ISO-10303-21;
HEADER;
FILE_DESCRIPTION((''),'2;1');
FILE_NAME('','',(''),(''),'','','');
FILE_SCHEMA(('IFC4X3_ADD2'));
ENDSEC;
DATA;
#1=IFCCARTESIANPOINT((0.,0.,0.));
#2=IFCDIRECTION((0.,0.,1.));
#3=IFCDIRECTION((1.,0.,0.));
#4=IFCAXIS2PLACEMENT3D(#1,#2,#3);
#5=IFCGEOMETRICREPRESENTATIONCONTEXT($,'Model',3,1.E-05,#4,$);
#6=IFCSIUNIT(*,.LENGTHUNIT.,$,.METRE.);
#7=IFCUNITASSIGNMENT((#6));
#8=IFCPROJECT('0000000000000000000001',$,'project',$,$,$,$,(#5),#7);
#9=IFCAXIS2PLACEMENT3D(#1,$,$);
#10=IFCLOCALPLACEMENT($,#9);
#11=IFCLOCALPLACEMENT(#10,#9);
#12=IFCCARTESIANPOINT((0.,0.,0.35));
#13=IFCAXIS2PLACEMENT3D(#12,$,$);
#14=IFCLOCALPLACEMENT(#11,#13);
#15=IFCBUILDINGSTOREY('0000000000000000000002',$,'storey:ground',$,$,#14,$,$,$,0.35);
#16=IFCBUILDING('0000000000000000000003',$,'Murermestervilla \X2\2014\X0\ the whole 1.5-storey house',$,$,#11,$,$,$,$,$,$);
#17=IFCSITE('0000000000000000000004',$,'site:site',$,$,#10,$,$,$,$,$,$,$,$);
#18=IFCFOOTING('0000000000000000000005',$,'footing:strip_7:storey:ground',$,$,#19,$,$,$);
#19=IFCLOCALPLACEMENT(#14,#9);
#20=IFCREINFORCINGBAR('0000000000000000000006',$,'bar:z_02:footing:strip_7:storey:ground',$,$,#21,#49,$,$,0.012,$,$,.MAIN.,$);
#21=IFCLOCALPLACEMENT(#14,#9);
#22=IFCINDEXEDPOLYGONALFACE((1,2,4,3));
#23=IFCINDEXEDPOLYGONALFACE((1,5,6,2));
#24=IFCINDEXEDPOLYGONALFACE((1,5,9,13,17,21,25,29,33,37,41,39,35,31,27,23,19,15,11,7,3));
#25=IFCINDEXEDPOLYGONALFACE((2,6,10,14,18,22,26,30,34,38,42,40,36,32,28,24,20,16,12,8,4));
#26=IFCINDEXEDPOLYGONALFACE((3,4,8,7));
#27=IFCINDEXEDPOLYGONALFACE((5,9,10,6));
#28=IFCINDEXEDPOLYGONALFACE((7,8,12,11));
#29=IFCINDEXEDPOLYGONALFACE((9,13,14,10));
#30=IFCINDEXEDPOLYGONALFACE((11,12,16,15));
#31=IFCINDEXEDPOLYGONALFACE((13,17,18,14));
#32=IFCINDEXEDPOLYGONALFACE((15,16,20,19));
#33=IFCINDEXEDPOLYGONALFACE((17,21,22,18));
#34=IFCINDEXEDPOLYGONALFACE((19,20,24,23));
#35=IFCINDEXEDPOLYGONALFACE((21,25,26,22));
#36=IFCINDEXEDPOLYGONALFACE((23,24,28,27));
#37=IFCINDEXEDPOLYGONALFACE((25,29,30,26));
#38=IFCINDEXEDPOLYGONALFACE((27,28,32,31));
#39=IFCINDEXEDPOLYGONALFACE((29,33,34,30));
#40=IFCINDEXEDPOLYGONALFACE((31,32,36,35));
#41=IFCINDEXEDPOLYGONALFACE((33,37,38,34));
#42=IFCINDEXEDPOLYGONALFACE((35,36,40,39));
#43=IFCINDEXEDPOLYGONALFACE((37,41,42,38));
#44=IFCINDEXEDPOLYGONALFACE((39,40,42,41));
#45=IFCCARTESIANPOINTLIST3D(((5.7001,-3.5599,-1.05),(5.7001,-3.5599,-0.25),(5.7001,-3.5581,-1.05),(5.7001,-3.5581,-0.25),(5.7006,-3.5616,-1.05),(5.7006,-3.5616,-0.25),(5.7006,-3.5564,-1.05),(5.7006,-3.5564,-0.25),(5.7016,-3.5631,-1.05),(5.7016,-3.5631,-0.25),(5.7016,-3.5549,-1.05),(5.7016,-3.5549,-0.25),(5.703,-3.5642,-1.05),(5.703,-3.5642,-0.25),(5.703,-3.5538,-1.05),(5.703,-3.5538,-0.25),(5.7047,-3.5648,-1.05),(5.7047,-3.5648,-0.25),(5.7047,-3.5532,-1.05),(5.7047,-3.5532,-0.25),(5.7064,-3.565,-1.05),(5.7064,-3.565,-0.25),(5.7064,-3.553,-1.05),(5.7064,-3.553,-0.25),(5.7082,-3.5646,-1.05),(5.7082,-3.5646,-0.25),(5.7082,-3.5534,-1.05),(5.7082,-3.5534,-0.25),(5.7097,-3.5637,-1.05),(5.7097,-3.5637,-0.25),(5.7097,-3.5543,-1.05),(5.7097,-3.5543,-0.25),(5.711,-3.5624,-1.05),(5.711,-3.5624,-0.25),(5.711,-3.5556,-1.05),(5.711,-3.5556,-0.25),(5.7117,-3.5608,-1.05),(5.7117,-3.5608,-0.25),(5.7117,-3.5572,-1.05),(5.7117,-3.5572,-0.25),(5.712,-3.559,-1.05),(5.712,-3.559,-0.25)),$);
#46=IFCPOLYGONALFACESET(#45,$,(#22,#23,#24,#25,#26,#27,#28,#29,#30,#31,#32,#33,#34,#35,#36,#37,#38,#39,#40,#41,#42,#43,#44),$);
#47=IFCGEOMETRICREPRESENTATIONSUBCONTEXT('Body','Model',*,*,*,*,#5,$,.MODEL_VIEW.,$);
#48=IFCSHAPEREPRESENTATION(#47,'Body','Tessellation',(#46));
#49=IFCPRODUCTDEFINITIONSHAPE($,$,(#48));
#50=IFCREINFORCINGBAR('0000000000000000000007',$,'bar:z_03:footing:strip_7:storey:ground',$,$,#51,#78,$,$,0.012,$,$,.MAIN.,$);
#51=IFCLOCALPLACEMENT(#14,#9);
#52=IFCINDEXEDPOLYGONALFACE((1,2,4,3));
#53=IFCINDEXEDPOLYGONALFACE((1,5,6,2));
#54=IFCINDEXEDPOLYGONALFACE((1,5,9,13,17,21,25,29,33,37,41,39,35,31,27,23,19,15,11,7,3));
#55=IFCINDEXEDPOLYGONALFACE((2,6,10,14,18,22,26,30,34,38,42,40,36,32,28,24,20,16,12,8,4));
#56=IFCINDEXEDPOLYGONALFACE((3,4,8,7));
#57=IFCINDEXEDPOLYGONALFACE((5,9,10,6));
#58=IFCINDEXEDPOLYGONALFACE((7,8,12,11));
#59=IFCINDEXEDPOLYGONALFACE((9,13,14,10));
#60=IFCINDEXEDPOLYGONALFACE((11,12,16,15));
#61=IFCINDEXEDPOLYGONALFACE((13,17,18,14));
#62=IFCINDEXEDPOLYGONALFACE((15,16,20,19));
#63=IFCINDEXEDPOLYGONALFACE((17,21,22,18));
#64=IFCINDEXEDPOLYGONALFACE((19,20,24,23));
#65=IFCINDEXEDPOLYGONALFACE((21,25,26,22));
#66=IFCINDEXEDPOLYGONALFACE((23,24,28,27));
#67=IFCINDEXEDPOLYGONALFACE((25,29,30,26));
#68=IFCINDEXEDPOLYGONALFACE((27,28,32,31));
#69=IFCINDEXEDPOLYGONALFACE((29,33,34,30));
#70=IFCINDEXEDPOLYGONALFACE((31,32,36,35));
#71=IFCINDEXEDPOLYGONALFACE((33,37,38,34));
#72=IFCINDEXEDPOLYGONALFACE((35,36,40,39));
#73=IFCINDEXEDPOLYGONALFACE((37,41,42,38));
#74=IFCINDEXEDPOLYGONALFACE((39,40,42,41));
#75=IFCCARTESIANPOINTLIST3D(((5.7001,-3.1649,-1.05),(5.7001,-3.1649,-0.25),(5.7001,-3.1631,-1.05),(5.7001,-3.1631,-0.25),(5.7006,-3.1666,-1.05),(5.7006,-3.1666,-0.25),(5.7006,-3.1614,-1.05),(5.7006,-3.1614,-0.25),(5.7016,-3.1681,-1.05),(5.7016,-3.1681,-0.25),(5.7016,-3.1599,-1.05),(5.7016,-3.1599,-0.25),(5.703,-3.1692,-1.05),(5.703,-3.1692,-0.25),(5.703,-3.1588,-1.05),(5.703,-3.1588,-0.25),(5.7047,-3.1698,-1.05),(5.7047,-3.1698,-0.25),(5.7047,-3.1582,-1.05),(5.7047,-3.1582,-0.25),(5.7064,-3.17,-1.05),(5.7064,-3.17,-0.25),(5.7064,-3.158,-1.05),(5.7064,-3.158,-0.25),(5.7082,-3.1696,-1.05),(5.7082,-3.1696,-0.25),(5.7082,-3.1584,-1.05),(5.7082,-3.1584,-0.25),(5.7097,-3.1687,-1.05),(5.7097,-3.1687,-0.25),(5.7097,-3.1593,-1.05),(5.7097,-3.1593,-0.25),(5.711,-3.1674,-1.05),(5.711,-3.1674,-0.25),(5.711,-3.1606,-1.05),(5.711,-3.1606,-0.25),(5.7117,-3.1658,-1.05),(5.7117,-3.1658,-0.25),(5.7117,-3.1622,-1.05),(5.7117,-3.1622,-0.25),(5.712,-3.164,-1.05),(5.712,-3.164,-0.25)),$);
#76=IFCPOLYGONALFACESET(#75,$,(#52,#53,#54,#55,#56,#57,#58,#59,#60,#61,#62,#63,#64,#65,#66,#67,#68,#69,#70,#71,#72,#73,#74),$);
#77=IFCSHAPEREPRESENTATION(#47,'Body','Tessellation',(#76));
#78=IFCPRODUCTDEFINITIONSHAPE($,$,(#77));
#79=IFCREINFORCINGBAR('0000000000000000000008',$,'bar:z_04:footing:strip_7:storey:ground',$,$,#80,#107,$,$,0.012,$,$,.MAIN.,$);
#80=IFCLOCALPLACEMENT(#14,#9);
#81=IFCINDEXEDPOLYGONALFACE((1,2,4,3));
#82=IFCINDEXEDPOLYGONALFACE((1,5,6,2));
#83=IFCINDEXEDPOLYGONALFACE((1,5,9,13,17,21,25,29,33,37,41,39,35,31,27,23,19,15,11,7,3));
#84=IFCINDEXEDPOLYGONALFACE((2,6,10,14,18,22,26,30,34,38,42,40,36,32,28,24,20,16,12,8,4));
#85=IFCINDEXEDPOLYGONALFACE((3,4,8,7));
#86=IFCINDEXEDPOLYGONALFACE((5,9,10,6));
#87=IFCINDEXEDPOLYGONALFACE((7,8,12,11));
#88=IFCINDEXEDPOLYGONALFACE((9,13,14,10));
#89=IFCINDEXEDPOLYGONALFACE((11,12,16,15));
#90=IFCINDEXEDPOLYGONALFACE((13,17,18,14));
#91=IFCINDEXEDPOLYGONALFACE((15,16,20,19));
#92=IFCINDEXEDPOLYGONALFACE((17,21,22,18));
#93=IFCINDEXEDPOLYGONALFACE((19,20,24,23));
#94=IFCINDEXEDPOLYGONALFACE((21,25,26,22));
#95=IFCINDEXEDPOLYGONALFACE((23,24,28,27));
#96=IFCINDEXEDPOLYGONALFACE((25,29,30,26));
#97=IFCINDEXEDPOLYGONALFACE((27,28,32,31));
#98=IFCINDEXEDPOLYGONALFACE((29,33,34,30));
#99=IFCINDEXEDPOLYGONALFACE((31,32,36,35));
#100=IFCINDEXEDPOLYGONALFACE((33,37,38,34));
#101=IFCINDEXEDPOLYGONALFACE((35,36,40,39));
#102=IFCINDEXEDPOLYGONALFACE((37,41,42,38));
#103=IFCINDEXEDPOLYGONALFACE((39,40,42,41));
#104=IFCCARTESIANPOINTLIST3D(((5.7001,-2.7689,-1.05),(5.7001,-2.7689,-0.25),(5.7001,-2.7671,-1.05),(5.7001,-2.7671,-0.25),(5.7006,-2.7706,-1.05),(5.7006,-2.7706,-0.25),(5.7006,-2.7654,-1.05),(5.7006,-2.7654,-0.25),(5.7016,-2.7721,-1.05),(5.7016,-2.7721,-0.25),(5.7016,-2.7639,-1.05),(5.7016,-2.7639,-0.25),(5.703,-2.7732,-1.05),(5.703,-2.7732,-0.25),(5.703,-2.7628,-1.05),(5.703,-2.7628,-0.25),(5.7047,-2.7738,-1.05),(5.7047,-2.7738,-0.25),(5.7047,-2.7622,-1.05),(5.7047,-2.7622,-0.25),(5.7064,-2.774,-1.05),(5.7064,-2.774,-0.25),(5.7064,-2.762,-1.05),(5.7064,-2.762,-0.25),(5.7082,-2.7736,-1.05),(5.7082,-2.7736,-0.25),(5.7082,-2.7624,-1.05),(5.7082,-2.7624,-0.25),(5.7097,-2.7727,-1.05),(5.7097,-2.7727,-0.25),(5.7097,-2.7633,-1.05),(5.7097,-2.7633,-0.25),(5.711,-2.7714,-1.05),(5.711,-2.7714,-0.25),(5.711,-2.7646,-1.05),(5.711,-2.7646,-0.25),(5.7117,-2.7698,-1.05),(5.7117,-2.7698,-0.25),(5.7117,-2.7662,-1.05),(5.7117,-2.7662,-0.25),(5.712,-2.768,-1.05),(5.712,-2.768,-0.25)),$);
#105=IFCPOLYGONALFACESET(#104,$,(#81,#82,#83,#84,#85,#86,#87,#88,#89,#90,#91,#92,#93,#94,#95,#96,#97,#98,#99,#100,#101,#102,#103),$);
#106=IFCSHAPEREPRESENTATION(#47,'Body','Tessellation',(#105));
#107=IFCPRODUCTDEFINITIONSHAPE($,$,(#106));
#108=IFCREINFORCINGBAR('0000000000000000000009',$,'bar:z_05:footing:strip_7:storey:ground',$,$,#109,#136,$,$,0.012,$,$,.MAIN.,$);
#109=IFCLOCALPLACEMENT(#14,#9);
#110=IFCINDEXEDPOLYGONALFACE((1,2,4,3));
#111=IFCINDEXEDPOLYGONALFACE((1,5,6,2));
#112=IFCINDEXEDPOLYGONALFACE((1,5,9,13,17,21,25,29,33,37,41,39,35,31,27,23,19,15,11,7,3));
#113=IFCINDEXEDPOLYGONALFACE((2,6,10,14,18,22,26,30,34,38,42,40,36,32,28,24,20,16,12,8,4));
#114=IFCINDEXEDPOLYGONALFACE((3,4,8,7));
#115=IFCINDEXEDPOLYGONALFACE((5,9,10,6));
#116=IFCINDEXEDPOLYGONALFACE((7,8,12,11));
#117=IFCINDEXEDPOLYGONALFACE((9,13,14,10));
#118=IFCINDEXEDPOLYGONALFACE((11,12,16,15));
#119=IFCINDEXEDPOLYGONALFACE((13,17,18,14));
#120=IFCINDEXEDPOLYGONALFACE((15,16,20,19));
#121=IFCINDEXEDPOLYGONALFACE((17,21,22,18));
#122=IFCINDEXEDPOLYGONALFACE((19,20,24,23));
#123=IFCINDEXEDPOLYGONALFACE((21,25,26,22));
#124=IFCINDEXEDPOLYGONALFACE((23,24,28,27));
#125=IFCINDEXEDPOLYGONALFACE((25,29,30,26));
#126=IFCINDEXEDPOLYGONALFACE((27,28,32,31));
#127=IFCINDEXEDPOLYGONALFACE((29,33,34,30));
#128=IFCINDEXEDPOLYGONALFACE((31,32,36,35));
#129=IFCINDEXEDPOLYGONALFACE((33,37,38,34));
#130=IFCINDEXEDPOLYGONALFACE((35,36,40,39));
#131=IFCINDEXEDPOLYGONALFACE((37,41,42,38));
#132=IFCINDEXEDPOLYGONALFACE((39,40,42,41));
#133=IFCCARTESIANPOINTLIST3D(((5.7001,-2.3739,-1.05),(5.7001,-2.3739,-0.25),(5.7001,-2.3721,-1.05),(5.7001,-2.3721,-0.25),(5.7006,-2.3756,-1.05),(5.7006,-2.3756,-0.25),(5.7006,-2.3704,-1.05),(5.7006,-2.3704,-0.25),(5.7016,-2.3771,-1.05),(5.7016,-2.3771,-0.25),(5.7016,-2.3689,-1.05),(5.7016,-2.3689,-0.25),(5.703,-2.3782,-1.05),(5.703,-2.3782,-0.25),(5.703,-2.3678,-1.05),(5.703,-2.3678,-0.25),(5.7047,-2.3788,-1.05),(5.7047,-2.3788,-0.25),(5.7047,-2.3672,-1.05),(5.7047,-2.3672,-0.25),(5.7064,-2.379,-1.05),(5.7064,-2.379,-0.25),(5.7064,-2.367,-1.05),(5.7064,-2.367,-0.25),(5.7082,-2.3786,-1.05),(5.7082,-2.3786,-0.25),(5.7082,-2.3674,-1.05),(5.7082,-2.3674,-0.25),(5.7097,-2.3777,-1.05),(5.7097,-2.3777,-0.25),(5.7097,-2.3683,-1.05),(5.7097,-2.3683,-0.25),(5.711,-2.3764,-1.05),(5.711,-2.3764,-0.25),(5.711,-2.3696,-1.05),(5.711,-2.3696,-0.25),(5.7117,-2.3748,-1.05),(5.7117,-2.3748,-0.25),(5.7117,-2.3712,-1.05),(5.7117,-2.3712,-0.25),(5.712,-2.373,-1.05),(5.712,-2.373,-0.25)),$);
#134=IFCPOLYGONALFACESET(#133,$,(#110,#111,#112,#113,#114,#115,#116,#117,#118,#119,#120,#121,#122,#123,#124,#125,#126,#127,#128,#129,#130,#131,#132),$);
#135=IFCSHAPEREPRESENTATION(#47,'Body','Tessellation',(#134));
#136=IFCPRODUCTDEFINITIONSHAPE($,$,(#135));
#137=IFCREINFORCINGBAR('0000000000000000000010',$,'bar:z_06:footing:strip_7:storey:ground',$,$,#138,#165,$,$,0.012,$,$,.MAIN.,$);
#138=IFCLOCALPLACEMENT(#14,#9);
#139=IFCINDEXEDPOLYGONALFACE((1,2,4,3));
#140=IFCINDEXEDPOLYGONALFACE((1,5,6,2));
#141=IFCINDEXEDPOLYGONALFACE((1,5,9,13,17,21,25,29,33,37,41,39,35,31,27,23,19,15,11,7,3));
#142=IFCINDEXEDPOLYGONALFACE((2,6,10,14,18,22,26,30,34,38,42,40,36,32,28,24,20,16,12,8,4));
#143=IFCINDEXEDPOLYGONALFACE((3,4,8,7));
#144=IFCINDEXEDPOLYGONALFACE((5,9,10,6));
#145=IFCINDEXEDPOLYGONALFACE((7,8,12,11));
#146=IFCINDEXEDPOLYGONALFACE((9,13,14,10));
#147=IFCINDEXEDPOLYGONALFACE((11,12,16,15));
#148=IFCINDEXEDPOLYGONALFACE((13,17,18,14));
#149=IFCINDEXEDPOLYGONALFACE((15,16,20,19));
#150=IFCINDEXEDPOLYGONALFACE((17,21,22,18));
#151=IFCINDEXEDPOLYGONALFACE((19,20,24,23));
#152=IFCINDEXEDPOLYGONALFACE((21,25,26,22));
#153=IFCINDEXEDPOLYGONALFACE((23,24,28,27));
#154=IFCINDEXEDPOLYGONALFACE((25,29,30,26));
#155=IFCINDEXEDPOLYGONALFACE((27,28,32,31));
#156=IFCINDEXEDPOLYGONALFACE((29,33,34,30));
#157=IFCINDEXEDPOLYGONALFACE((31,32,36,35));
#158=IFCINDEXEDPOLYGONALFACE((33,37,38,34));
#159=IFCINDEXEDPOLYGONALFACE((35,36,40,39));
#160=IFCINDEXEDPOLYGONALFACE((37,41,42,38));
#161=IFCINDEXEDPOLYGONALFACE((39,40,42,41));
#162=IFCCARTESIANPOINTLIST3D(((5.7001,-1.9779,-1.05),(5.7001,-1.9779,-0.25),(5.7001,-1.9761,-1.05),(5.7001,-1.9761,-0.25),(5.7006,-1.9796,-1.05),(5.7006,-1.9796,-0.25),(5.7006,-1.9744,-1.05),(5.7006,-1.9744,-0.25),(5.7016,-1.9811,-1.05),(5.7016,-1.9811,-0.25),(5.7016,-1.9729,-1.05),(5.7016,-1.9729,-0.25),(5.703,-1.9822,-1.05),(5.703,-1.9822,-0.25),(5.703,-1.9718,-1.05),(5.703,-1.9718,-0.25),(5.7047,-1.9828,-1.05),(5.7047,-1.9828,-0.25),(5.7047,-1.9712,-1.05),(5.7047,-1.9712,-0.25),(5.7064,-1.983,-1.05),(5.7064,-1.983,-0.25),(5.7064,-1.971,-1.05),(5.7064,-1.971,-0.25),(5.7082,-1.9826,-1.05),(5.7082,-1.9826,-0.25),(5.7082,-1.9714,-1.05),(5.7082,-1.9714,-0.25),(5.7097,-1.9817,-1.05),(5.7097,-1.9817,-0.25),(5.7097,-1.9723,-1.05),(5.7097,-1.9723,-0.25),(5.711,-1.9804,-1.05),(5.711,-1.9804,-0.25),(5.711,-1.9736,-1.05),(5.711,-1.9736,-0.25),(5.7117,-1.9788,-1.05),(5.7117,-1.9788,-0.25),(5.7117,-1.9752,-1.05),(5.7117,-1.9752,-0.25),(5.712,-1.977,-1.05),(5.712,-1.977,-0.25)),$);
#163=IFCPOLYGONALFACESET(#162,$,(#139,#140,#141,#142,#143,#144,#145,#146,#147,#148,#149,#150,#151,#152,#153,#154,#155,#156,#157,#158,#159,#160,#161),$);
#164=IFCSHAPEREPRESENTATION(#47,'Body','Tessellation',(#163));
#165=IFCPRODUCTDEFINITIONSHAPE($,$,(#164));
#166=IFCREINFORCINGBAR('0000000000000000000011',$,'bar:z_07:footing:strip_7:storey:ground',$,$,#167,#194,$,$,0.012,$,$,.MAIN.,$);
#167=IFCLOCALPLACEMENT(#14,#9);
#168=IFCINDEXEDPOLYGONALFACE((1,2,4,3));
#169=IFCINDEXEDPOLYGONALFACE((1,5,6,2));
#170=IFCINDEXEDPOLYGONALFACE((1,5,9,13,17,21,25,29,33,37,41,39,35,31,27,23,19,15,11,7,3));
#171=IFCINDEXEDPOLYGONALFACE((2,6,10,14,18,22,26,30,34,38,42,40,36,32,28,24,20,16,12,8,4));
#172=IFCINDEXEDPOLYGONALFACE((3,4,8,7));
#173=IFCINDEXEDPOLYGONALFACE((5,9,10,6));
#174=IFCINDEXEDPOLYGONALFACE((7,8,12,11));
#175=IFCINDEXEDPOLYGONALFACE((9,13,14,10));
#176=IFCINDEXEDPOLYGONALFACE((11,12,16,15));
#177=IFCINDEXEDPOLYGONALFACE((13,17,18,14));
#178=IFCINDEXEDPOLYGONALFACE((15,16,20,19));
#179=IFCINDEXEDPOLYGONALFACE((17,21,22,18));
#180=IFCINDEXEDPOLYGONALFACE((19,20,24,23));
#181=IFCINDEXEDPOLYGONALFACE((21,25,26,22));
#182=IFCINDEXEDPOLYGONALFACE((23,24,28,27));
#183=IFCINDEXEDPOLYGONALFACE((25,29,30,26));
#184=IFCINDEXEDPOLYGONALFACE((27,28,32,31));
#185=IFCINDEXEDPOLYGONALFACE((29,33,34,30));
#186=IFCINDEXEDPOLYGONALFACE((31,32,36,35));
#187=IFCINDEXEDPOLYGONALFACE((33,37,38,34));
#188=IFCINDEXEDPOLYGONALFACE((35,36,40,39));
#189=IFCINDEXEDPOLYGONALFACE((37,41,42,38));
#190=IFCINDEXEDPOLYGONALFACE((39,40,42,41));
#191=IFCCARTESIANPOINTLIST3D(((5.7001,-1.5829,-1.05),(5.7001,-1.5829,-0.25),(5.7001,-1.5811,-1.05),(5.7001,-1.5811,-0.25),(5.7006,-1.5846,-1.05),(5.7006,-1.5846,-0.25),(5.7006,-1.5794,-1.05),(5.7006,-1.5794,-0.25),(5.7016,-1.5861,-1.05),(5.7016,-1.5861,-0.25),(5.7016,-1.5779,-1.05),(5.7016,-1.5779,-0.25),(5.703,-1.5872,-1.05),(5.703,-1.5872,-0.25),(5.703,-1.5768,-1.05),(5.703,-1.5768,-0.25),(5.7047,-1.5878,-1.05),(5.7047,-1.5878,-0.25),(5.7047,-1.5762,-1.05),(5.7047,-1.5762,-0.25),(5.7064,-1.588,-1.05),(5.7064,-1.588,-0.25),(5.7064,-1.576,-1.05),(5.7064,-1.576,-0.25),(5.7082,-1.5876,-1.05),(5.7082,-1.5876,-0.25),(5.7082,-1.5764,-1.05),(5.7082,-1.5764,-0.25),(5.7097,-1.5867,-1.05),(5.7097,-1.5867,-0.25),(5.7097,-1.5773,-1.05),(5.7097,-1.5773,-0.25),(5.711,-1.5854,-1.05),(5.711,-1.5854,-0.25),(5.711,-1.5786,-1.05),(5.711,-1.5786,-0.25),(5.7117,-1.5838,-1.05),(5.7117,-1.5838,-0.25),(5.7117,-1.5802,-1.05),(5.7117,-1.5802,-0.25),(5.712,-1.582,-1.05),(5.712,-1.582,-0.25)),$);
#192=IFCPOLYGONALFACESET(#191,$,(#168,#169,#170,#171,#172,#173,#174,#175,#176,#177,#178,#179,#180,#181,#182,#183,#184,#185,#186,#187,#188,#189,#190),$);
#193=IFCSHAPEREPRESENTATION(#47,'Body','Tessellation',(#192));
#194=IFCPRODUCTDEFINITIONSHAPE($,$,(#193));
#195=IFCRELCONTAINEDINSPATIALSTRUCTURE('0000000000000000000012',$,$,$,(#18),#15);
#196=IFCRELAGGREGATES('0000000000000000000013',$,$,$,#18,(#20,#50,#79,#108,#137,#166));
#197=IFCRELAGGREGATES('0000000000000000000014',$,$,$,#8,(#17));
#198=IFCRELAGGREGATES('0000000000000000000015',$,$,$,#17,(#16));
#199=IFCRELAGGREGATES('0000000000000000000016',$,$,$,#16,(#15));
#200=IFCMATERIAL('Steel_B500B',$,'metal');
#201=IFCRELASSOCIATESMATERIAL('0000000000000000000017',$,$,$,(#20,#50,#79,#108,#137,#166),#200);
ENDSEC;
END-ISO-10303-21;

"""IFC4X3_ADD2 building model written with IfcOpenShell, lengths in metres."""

from ifc_helpers import new_model, entity, si_unit, frame, origin, origin_with_axes, place, context, subcontext, project, spatial, material, element, aggregate, save


model = new_model("IFC4X3_ADD2")

# Units and contexts
model_context = context("Model", 3, precision=1e-05, world=origin_with_axes())
body_context = subcontext(model_context, "Body", "Model", "MODEL_VIEW")
ifc_project = project(units=[si_unit("LENGTHUNIT", "METRE")], contexts=[model_context])

# Site, building, storey
placement_1 = place(None, origin())
site = spatial("IfcSite", under=ifc_project, at=placement_1, Name="site:site")
building_placement = place(placement_1, origin())
building = spatial("IfcBuilding", under=site, at=building_placement, Name="Murermestervilla — the whole 1.5-storey house")
storey_placement = place(building_placement, frame((0.0, 0.0, 0.35)))
storey = spatial("IfcBuildingStorey", under=building, at=storey_placement, Name="storey:ground", Elevation=0.35)

# Footing, reinforcing bars
placement_2 = place(storey_placement, frame((0.0, 0.0, -0.35)))
ifc_material = material(Name="Steel_B500B", Category="metal")
footing_1 = element("IfcFooting", 1, at=placement_2, inside=storey, Name="footing:strip_7:storey:ground")
reinforcing_bar_1 = element("IfcReinforcingBar", 2, at=placement_1, material=ifc_material, Name="bar:z_02:footing:strip_7:storey:ground", NominalDiameter=0.012, PredefinedType="MAIN", context=body_context, shape_type="AdvancedSweptSolid", body=[
    entity("IfcSweptDiskSolid", entity("IfcPolyline", [entity("IfcCartesianPoint", [5.706, -3.559, -0.7]), entity("IfcCartesianPoint", [5.706, -3.559, 0.1])]), 0.006),
])
reinforcing_bar_2 = element("IfcReinforcingBar", 3, at=placement_1, material=ifc_material, Name="bar:z_03:footing:strip_7:storey:ground", NominalDiameter=0.012, PredefinedType="MAIN", context=body_context, shape_type="AdvancedSweptSolid", body=[
    entity("IfcSweptDiskSolid", entity("IfcPolyline", [entity("IfcCartesianPoint", [5.706, -3.164, -0.7]), entity("IfcCartesianPoint", [5.706, -3.164, 0.1])]), 0.006),
])
reinforcing_bar_3 = element("IfcReinforcingBar", 4, at=placement_1, material=ifc_material, Name="bar:z_04:footing:strip_7:storey:ground", NominalDiameter=0.012, PredefinedType="MAIN", context=body_context, shape_type="AdvancedSweptSolid", body=[
    entity("IfcSweptDiskSolid", entity("IfcPolyline", [entity("IfcCartesianPoint", [5.706, -2.768, -0.7]), entity("IfcCartesianPoint", [5.706, -2.768, 0.1])]), 0.006),
])
reinforcing_bar_4 = element("IfcReinforcingBar", 5, at=placement_1, material=ifc_material, Name="bar:z_05:footing:strip_7:storey:ground", NominalDiameter=0.012, PredefinedType="MAIN", context=body_context, shape_type="AdvancedSweptSolid", body=[
    entity("IfcSweptDiskSolid", entity("IfcPolyline", [entity("IfcCartesianPoint", [5.706, -2.373, -0.7]), entity("IfcCartesianPoint", [5.706, -2.373, 0.1])]), 0.006),
])
reinforcing_bar_5 = element("IfcReinforcingBar", 6, at=placement_1, material=ifc_material, Name="bar:z_06:footing:strip_7:storey:ground", NominalDiameter=0.012, PredefinedType="MAIN", context=body_context, shape_type="AdvancedSweptSolid", body=[
    entity("IfcSweptDiskSolid", entity("IfcPolyline", [entity("IfcCartesianPoint", [5.706, -1.977, -0.7]), entity("IfcCartesianPoint", [5.706, -1.977, 0.1])]), 0.006),
])
reinforcing_bar_6 = element("IfcReinforcingBar", 7, at=placement_1, material=ifc_material, Name="bar:z_07:footing:strip_7:storey:ground", NominalDiameter=0.012, PredefinedType="MAIN", context=body_context, shape_type="AdvancedSweptSolid", body=[
    entity("IfcSweptDiskSolid", entity("IfcPolyline", [entity("IfcCartesianPoint", [5.706, -1.582, -0.7]), entity("IfcCartesianPoint", [5.706, -1.582, 0.1])]), 0.006),
])
aggregate(footing_1, [reinforcing_bar_1, reinforcing_bar_2, reinforcing_bar_3, reinforcing_bar_4, reinforcing_bar_5, reinforcing_bar_6])

save(model, "model.ifc")
